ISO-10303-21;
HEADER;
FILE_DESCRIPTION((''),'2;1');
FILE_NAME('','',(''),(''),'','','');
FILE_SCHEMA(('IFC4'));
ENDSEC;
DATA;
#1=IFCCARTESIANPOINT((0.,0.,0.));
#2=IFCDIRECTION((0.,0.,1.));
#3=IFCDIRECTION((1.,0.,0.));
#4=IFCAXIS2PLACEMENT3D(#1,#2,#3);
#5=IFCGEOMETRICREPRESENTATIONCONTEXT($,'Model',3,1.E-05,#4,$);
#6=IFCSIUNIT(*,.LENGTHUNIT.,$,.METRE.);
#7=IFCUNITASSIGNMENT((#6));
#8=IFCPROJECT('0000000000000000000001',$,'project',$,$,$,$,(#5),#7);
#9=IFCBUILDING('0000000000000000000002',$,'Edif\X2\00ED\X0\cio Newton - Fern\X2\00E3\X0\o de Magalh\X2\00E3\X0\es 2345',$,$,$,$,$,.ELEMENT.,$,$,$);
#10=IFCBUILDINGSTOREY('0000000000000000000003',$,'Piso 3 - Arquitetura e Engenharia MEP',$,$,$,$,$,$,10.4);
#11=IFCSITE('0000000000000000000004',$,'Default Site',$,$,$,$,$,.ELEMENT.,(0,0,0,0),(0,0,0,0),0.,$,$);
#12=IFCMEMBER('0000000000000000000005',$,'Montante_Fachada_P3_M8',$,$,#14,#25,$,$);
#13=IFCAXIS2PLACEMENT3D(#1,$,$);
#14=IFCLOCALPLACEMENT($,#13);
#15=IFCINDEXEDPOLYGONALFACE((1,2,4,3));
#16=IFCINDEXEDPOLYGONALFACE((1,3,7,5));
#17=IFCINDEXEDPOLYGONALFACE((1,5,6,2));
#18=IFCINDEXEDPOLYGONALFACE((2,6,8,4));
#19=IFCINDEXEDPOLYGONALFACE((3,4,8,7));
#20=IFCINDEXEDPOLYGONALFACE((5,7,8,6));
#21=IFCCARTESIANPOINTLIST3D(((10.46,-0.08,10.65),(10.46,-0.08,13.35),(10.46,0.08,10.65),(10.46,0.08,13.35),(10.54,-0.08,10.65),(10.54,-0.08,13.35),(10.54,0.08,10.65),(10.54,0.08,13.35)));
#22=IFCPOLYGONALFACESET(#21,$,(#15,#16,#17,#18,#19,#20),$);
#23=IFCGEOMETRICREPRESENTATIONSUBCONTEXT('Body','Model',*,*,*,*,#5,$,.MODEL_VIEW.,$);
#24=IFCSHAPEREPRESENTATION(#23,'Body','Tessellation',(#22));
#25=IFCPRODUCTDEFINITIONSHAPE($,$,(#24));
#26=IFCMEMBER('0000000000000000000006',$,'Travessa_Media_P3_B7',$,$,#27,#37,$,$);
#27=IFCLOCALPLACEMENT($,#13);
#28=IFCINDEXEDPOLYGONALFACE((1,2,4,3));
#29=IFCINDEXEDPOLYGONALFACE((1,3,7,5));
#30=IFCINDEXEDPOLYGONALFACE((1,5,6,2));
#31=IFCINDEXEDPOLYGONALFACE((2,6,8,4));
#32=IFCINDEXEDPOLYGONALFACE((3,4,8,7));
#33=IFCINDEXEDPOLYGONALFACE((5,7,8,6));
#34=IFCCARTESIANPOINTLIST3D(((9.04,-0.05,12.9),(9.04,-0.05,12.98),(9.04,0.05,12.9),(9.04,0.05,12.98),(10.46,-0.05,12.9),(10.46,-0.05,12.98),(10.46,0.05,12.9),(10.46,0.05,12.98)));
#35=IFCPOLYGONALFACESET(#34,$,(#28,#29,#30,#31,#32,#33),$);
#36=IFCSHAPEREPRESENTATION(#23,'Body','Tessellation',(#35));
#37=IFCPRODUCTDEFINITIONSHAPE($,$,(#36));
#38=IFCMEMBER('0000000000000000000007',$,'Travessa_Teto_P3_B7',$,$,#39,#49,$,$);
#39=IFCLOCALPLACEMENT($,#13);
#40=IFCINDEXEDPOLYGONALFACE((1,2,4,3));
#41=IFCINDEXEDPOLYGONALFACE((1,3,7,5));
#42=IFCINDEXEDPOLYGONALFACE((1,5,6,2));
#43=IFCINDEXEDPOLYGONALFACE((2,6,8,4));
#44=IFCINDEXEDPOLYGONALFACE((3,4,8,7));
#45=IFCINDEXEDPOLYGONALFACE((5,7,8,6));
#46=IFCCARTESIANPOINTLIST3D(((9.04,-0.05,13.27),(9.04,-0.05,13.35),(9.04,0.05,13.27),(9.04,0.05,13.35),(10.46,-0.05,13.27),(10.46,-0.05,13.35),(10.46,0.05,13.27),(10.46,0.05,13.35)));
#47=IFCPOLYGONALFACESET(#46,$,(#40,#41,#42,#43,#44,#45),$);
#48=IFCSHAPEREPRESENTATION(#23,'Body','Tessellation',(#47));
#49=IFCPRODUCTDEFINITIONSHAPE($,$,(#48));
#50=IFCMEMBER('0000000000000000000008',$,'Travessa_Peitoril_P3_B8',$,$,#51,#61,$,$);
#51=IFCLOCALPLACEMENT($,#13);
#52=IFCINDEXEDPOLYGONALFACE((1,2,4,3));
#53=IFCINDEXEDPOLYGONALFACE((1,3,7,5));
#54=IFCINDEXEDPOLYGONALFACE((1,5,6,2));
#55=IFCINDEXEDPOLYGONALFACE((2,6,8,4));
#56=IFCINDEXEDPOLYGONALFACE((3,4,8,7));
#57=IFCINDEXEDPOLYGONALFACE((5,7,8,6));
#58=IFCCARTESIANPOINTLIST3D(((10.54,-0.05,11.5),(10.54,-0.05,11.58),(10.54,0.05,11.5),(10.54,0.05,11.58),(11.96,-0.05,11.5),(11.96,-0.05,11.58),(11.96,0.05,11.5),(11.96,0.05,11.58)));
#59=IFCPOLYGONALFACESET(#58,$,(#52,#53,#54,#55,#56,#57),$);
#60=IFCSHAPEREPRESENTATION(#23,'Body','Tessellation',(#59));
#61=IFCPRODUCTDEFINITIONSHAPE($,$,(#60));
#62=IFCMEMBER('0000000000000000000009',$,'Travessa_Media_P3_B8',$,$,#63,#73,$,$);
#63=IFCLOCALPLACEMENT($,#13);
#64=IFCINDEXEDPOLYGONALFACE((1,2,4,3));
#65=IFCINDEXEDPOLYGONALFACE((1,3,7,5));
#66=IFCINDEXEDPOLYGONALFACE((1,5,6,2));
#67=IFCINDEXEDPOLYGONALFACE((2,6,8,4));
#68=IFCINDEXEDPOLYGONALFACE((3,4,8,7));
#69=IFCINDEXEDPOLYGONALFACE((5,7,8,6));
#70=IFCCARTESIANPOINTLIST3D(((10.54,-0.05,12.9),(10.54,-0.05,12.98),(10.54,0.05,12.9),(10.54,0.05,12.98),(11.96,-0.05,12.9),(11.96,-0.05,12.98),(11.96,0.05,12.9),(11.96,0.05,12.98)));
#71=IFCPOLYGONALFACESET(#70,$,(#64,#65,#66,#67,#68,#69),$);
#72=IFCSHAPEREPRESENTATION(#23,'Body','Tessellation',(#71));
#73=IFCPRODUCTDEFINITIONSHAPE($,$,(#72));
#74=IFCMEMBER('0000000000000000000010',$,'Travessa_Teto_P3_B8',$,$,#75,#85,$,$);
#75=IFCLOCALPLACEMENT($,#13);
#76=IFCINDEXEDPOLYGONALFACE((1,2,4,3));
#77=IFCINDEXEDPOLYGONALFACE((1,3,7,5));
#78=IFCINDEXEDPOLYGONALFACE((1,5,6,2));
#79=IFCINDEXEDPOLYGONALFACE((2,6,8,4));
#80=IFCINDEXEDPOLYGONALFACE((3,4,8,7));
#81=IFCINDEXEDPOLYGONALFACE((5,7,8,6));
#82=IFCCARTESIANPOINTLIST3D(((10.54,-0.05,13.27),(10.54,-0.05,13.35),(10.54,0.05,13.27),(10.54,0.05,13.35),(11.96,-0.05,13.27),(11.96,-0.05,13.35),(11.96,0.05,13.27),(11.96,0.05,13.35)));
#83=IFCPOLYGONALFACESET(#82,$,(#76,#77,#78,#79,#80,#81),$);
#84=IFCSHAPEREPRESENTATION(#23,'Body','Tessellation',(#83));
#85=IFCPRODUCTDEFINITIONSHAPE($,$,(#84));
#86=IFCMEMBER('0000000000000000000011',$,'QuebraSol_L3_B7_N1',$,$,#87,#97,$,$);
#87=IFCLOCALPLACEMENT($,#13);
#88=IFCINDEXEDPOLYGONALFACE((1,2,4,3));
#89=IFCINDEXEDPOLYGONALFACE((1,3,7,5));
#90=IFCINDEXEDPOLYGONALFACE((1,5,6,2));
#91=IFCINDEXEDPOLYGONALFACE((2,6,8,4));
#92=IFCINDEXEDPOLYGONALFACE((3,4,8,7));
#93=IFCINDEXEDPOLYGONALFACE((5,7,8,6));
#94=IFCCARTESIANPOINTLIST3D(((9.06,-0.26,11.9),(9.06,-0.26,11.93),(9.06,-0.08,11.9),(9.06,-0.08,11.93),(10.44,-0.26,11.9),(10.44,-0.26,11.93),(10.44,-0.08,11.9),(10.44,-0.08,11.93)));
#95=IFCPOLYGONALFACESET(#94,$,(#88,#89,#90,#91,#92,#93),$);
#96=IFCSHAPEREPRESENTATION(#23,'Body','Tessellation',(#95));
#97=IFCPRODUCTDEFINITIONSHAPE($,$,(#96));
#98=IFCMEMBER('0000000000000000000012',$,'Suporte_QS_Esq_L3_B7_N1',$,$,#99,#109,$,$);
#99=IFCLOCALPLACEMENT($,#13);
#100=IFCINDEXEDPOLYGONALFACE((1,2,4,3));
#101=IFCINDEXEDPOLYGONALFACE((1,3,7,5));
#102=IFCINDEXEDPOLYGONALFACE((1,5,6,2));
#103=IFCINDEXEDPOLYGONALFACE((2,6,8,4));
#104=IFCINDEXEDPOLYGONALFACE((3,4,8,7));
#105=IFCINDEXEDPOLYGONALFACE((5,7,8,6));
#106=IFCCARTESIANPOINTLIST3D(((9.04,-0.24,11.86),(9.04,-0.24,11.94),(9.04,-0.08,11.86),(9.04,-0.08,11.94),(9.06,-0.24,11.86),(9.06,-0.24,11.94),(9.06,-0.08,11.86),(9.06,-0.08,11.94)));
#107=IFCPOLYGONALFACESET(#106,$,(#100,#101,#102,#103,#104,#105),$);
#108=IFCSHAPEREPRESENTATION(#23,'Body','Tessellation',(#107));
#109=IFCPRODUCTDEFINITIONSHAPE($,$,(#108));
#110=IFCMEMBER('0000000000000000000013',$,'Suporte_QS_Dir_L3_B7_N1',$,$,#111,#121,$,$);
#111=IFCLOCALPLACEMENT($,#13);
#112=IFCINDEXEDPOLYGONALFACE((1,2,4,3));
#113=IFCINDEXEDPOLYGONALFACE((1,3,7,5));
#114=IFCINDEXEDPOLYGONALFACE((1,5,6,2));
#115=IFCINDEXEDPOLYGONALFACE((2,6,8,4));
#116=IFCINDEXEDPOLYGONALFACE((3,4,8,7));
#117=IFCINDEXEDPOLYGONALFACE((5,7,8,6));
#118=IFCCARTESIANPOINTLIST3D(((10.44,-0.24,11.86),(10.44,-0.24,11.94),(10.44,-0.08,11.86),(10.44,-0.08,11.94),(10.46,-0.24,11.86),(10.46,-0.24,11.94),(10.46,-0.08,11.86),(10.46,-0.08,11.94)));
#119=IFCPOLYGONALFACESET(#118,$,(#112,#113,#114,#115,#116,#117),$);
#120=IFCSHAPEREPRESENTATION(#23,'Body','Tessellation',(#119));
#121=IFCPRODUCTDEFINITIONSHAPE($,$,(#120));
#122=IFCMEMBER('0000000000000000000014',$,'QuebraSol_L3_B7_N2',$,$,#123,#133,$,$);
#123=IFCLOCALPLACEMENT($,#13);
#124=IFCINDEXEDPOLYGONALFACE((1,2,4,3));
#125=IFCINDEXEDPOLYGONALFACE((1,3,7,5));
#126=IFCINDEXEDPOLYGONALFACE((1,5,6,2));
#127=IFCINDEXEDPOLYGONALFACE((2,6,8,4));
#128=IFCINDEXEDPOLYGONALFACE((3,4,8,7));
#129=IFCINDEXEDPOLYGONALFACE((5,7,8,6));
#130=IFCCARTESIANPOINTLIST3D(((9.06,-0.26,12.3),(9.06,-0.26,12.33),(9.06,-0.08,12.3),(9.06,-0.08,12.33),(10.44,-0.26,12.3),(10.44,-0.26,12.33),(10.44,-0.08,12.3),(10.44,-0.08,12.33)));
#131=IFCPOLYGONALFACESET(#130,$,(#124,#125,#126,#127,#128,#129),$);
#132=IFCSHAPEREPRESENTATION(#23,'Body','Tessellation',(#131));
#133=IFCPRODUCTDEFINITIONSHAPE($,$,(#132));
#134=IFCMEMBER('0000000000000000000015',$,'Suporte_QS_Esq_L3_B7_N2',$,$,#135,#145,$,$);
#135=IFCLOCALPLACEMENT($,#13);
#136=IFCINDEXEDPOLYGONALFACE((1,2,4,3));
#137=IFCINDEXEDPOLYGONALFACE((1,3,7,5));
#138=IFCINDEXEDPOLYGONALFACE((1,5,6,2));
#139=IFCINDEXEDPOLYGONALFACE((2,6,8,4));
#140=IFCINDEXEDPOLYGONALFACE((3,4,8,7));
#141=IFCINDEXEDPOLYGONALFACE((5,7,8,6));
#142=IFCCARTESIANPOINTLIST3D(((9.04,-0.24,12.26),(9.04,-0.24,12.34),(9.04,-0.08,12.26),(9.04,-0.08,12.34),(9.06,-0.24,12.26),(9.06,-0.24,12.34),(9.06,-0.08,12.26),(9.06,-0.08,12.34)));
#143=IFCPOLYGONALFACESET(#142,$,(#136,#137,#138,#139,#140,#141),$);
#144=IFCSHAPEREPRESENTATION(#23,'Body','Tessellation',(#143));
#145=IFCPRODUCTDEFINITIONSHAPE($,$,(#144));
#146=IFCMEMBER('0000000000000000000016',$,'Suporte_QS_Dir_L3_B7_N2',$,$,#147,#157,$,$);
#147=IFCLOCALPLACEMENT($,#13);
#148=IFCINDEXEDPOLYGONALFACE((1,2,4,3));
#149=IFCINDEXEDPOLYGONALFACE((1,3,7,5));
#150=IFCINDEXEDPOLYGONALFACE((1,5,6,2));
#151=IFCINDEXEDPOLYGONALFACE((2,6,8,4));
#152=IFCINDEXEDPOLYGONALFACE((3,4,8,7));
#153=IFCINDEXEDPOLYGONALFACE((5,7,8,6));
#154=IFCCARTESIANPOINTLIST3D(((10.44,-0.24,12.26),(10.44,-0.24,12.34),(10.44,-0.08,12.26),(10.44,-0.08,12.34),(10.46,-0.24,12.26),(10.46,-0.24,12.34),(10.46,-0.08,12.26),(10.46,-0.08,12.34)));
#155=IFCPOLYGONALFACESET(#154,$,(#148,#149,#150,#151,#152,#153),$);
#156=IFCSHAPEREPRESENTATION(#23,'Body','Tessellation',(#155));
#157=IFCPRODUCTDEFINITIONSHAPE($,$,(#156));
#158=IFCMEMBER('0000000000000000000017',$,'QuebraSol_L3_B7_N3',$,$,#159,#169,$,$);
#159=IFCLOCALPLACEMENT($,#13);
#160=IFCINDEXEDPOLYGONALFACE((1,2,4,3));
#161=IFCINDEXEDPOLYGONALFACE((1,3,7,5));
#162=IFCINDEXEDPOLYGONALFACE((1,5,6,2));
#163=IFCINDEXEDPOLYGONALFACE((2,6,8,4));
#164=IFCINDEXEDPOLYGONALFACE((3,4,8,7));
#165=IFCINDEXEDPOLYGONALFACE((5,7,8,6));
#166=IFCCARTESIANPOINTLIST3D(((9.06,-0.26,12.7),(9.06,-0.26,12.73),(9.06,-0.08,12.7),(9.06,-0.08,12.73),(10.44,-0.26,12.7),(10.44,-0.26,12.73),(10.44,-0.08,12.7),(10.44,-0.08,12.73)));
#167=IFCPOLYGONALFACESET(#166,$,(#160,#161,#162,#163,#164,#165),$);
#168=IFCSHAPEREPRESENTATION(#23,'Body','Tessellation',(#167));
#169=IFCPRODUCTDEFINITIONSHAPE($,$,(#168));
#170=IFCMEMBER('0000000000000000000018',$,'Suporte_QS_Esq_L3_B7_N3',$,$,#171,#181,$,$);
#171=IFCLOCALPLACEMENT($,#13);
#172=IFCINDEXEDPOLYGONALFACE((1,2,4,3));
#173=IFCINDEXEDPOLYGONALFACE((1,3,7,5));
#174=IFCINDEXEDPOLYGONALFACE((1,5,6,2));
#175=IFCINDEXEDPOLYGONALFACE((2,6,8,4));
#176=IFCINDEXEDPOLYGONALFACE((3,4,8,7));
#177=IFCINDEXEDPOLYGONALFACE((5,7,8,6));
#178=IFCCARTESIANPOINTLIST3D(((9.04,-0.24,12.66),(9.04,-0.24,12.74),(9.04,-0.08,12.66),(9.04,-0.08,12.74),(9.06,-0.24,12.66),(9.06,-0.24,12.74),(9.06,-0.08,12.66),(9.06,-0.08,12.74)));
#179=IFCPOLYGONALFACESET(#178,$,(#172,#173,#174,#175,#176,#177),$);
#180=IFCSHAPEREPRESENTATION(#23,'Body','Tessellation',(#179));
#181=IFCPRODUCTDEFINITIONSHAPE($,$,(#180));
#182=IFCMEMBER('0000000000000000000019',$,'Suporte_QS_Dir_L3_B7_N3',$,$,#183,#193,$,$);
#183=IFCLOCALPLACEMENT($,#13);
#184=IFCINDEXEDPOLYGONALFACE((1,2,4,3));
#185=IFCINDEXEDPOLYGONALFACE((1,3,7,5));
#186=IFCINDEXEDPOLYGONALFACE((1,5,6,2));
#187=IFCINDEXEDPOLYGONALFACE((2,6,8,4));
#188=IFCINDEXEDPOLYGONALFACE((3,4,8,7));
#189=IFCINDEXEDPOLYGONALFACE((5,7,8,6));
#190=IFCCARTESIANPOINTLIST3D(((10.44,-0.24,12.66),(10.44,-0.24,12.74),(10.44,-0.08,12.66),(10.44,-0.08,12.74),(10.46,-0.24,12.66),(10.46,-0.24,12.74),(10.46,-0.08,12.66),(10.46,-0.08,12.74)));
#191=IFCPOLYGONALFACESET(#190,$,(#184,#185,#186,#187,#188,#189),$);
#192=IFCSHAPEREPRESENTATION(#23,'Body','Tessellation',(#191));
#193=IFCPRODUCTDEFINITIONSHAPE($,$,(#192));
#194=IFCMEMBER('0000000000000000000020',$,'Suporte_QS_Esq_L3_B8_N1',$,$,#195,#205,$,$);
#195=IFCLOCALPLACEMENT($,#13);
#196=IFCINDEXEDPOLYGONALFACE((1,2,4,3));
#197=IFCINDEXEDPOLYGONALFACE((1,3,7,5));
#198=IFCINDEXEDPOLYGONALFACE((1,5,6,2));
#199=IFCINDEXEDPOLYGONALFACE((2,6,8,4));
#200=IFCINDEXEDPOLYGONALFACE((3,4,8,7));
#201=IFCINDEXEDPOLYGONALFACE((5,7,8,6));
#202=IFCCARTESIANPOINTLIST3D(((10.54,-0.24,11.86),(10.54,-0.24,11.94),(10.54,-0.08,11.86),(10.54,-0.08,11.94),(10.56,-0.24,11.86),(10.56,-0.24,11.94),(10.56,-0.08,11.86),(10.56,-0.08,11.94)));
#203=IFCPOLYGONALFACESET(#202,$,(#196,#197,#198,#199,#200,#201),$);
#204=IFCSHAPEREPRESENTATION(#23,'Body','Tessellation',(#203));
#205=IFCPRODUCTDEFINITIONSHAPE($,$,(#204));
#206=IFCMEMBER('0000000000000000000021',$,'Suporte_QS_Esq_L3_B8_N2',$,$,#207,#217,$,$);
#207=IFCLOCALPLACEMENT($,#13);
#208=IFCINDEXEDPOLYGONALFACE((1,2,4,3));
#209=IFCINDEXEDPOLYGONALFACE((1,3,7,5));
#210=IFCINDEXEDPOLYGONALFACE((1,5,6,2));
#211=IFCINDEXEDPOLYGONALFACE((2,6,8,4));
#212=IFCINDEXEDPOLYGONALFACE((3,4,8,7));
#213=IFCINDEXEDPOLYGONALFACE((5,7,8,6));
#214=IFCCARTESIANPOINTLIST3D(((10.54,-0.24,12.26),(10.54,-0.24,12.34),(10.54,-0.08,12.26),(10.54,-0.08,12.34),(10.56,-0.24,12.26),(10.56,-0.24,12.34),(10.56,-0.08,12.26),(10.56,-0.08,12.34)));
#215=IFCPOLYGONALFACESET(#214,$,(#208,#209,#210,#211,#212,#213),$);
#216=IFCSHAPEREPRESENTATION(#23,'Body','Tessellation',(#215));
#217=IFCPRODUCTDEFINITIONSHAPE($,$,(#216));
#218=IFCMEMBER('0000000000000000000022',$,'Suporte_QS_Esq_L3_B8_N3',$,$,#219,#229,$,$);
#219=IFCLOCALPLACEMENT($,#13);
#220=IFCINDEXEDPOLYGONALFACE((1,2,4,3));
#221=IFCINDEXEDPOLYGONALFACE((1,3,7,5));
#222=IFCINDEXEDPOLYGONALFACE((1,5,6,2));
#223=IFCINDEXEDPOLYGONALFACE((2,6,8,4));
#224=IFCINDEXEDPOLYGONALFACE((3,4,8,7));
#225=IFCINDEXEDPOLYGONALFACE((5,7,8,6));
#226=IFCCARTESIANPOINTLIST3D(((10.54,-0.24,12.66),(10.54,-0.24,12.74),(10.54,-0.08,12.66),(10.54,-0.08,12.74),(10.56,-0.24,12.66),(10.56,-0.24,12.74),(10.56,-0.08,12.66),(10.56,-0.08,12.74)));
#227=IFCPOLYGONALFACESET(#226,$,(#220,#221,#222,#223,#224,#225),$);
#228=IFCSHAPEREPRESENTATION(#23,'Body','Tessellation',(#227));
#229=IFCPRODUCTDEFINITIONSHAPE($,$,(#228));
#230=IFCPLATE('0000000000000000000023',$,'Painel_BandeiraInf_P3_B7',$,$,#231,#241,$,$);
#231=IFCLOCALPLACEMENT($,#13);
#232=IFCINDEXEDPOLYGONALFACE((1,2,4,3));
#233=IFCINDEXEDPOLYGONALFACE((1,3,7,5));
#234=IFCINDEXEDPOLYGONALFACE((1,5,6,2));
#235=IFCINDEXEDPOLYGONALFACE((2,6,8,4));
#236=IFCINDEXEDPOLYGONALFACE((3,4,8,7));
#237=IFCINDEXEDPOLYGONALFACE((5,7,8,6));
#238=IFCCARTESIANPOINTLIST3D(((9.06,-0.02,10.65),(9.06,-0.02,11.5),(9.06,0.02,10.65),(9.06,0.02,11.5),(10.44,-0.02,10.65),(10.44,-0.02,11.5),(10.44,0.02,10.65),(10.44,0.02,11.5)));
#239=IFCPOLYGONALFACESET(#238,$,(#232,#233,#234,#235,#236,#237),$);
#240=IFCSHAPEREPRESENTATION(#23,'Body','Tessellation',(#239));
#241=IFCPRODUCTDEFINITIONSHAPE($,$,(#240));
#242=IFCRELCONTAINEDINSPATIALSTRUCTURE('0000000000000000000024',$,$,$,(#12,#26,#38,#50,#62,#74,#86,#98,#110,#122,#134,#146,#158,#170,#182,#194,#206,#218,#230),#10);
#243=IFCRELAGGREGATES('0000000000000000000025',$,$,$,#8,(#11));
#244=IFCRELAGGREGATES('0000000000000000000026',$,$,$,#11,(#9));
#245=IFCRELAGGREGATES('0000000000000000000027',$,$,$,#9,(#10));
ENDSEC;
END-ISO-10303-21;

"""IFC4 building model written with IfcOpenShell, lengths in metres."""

from ifc_helpers import new_model, si_unit, frame, frame_2d, origin_with_axes, place, context, subcontext, project, spatial, rectangle, extrude, element, save


model = new_model("IFC4")

# Units and contexts
model_context = context("Model", 3, precision=1e-05, world=origin_with_axes())
body_context = subcontext(model_context, "Body", "Model", "MODEL_VIEW")
ifc_project = project(units=[si_unit("LENGTHUNIT", "METRE")], contexts=[model_context])

# Site, building, storey
site = spatial("IfcSite", under=ifc_project, Name="Default Site", CompositionType="ELEMENT", RefLatitude=(0, 0, 0, 0), RefLongitude=(0, 0, 0, 0), RefElevation=0.0)
building = spatial("IfcBuilding", under=site, Name="Edifício Newton - Fernão de Magalhães 2345", CompositionType="ELEMENT")
storey = spatial("IfcBuildingStorey", under=building, Name="Piso 3 - Arquitetura e Engenharia MEP", Elevation=10.4)

# Members
member_1_placement = place(None, frame((10.46, -0.08, 10.65), z_axis=(0.0, 0.0, 1.0), x_axis=(1.0, 0.0, 0.0)))
element("IfcMember", 1, at=member_1_placement, inside=storey, Name="Montante_Fachada_P3_M8", context=body_context, shape_type="SweptSolid", body=[
    extrude(rectangle(XDim=0.08, YDim=0.16, at=frame_2d((0.04, 0.08))), origin_with_axes(), (0.0, 0.0, 1.0), 2.7),
])
for number, where, z_axis, x_axis, name in (
    (2, (9.04, -0.05, 12.9), (0.0, 0.0, 1.0), (1.0, 0.0, 0.0), "Travessa_Media_P3_B7"),
    (3, (9.04, -0.05, 13.27), (0.0, 0.0, 1.0), (1.0, 0.0, 0.0), "Travessa_Teto_P3_B7"),
    (4, (10.54, -0.05, 11.5), (0.0, 0.0, 1.0), (1.0, 0.0, 0.0), "Travessa_Peitoril_P3_B8"),
    (5, (10.54, -0.05, 12.9), (0.0, 0.0, 1.0), (1.0, 0.0, 0.0), "Travessa_Media_P3_B8"),
    (6, (10.54, -0.05, 13.27), (0.0, 0.0, 1.0), (1.0, 0.0, 0.0), "Travessa_Teto_P3_B8"),
):
    element("IfcMember", number, at=place(None, frame(where, z_axis=z_axis, x_axis=x_axis)), inside=storey, Name=name, context=body_context, shape_type="SweptSolid", body=[
        extrude(rectangle(XDim=1.42, YDim=0.1, at=frame_2d((0.71, 0.05))), origin_with_axes(), (0.0, 0.0, 1.0), 0.08),
    ])
member_2_placement = place(None, frame((9.06, -0.26, 11.9), z_axis=(0.0, 0.0, 1.0), x_axis=(1.0, 0.0, 0.0)))
element("IfcMember", 7, at=member_2_placement, inside=storey, Name="QuebraSol_L3_B7_N1", context=body_context, shape_type="SweptSolid", body=[
    extrude(rectangle(XDim=1.38, YDim=0.18, at=frame_2d((0.69, 0.09))), origin_with_axes(), (0.0, 0.0, 1.0), 0.03),
])
for number, where, z_axis, x_axis, name in (
    (8, (9.04, -0.24, 11.86), (0.0, 0.0, 1.0), (1.0, 0.0, 0.0), "Suporte_QS_Esq_L3_B7_N1"),
    (9, (10.44, -0.24, 11.86), (0.0, 0.0, 1.0), (1.0, 0.0, 0.0), "Suporte_QS_Dir_L3_B7_N1"),
):
    element("IfcMember", number, at=place(None, frame(where, z_axis=z_axis, x_axis=x_axis)), inside=storey, Name=name, context=body_context, shape_type="SweptSolid", body=[
        extrude(rectangle(XDim=0.02, YDim=0.16, at=frame_2d((0.01, 0.08))), origin_with_axes(), (0.0, 0.0, 1.0), 0.08),
    ])
member_3_placement = place(None, frame((9.06, -0.26, 12.3), z_axis=(0.0, 0.0, 1.0), x_axis=(1.0, 0.0, 0.0)))
element("IfcMember", 10, at=member_3_placement, inside=storey, Name="QuebraSol_L3_B7_N2", context=body_context, shape_type="SweptSolid", body=[
    extrude(rectangle(XDim=1.38, YDim=0.18, at=frame_2d((0.69, 0.09))), origin_with_axes(), (0.0, 0.0, 1.0), 0.03),
])
for number, where, z_axis, x_axis, name in (
    (11, (9.04, -0.24, 12.26), (0.0, 0.0, 1.0), (1.0, 0.0, 0.0), "Suporte_QS_Esq_L3_B7_N2"),
    (12, (10.44, -0.24, 12.26), (0.0, 0.0, 1.0), (1.0, 0.0, 0.0), "Suporte_QS_Dir_L3_B7_N2"),
):
    element("IfcMember", number, at=place(None, frame(where, z_axis=z_axis, x_axis=x_axis)), inside=storey, Name=name, context=body_context, shape_type="SweptSolid", body=[
        extrude(rectangle(XDim=0.02, YDim=0.16, at=frame_2d((0.01, 0.08))), origin_with_axes(), (0.0, 0.0, 1.0), 0.08),
    ])
member_4_placement = place(None, frame((9.06, -0.26, 12.7), z_axis=(0.0, 0.0, 1.0), x_axis=(1.0, 0.0, 0.0)))
element("IfcMember", 13, at=member_4_placement, inside=storey, Name="QuebraSol_L3_B7_N3", context=body_context, shape_type="SweptSolid", body=[
    extrude(rectangle(XDim=1.38, YDim=0.18, at=frame_2d((0.69, 0.09))), origin_with_axes(), (0.0, 0.0, 1.0), 0.03),
])
for number, where, z_axis, x_axis, name in (
    (14, (9.04, -0.24, 12.66), (0.0, 0.0, 1.0), (1.0, 0.0, 0.0), "Suporte_QS_Esq_L3_B7_N3"),
    (15, (10.44, -0.24, 12.66), (0.0, 0.0, 1.0), (1.0, 0.0, 0.0), "Suporte_QS_Dir_L3_B7_N3"),
    (16, (10.54, -0.24, 11.86), (0.0, 0.0, 1.0), (1.0, 0.0, 0.0), "Suporte_QS_Esq_L3_B8_N1"),
    (17, (10.54, -0.24, 12.26), (0.0, 0.0, 1.0), (1.0, 0.0, 0.0), "Suporte_QS_Esq_L3_B8_N2"),
    (18, (10.54, -0.24, 12.66), (0.0, 0.0, 1.0), (1.0, 0.0, 0.0), "Suporte_QS_Esq_L3_B8_N3"),
):
    element("IfcMember", number, at=place(None, frame(where, z_axis=z_axis, x_axis=x_axis)), inside=storey, Name=name, context=body_context, shape_type="SweptSolid", body=[
        extrude(rectangle(XDim=0.02, YDim=0.16, at=frame_2d((0.01, 0.08))), origin_with_axes(), (0.0, 0.0, 1.0), 0.08),
    ])

# Plate
plate_1_placement = place(None, frame((9.06, -0.02, 10.65), z_axis=(0.0, 0.0, 1.0), x_axis=(1.0, 0.0, 0.0)))
element("IfcPlate", 19, at=plate_1_placement, inside=storey, Name="Painel_BandeiraInf_P3_B7", context=body_context, shape_type="SweptSolid", body=[
    extrude(rectangle(XDim=1.38, YDim=0.04, at=frame_2d((0.69, 0.02))), origin_with_axes(), (0.0, 0.0, 1.0), 0.85),
])

save(model, "model.ifc")
